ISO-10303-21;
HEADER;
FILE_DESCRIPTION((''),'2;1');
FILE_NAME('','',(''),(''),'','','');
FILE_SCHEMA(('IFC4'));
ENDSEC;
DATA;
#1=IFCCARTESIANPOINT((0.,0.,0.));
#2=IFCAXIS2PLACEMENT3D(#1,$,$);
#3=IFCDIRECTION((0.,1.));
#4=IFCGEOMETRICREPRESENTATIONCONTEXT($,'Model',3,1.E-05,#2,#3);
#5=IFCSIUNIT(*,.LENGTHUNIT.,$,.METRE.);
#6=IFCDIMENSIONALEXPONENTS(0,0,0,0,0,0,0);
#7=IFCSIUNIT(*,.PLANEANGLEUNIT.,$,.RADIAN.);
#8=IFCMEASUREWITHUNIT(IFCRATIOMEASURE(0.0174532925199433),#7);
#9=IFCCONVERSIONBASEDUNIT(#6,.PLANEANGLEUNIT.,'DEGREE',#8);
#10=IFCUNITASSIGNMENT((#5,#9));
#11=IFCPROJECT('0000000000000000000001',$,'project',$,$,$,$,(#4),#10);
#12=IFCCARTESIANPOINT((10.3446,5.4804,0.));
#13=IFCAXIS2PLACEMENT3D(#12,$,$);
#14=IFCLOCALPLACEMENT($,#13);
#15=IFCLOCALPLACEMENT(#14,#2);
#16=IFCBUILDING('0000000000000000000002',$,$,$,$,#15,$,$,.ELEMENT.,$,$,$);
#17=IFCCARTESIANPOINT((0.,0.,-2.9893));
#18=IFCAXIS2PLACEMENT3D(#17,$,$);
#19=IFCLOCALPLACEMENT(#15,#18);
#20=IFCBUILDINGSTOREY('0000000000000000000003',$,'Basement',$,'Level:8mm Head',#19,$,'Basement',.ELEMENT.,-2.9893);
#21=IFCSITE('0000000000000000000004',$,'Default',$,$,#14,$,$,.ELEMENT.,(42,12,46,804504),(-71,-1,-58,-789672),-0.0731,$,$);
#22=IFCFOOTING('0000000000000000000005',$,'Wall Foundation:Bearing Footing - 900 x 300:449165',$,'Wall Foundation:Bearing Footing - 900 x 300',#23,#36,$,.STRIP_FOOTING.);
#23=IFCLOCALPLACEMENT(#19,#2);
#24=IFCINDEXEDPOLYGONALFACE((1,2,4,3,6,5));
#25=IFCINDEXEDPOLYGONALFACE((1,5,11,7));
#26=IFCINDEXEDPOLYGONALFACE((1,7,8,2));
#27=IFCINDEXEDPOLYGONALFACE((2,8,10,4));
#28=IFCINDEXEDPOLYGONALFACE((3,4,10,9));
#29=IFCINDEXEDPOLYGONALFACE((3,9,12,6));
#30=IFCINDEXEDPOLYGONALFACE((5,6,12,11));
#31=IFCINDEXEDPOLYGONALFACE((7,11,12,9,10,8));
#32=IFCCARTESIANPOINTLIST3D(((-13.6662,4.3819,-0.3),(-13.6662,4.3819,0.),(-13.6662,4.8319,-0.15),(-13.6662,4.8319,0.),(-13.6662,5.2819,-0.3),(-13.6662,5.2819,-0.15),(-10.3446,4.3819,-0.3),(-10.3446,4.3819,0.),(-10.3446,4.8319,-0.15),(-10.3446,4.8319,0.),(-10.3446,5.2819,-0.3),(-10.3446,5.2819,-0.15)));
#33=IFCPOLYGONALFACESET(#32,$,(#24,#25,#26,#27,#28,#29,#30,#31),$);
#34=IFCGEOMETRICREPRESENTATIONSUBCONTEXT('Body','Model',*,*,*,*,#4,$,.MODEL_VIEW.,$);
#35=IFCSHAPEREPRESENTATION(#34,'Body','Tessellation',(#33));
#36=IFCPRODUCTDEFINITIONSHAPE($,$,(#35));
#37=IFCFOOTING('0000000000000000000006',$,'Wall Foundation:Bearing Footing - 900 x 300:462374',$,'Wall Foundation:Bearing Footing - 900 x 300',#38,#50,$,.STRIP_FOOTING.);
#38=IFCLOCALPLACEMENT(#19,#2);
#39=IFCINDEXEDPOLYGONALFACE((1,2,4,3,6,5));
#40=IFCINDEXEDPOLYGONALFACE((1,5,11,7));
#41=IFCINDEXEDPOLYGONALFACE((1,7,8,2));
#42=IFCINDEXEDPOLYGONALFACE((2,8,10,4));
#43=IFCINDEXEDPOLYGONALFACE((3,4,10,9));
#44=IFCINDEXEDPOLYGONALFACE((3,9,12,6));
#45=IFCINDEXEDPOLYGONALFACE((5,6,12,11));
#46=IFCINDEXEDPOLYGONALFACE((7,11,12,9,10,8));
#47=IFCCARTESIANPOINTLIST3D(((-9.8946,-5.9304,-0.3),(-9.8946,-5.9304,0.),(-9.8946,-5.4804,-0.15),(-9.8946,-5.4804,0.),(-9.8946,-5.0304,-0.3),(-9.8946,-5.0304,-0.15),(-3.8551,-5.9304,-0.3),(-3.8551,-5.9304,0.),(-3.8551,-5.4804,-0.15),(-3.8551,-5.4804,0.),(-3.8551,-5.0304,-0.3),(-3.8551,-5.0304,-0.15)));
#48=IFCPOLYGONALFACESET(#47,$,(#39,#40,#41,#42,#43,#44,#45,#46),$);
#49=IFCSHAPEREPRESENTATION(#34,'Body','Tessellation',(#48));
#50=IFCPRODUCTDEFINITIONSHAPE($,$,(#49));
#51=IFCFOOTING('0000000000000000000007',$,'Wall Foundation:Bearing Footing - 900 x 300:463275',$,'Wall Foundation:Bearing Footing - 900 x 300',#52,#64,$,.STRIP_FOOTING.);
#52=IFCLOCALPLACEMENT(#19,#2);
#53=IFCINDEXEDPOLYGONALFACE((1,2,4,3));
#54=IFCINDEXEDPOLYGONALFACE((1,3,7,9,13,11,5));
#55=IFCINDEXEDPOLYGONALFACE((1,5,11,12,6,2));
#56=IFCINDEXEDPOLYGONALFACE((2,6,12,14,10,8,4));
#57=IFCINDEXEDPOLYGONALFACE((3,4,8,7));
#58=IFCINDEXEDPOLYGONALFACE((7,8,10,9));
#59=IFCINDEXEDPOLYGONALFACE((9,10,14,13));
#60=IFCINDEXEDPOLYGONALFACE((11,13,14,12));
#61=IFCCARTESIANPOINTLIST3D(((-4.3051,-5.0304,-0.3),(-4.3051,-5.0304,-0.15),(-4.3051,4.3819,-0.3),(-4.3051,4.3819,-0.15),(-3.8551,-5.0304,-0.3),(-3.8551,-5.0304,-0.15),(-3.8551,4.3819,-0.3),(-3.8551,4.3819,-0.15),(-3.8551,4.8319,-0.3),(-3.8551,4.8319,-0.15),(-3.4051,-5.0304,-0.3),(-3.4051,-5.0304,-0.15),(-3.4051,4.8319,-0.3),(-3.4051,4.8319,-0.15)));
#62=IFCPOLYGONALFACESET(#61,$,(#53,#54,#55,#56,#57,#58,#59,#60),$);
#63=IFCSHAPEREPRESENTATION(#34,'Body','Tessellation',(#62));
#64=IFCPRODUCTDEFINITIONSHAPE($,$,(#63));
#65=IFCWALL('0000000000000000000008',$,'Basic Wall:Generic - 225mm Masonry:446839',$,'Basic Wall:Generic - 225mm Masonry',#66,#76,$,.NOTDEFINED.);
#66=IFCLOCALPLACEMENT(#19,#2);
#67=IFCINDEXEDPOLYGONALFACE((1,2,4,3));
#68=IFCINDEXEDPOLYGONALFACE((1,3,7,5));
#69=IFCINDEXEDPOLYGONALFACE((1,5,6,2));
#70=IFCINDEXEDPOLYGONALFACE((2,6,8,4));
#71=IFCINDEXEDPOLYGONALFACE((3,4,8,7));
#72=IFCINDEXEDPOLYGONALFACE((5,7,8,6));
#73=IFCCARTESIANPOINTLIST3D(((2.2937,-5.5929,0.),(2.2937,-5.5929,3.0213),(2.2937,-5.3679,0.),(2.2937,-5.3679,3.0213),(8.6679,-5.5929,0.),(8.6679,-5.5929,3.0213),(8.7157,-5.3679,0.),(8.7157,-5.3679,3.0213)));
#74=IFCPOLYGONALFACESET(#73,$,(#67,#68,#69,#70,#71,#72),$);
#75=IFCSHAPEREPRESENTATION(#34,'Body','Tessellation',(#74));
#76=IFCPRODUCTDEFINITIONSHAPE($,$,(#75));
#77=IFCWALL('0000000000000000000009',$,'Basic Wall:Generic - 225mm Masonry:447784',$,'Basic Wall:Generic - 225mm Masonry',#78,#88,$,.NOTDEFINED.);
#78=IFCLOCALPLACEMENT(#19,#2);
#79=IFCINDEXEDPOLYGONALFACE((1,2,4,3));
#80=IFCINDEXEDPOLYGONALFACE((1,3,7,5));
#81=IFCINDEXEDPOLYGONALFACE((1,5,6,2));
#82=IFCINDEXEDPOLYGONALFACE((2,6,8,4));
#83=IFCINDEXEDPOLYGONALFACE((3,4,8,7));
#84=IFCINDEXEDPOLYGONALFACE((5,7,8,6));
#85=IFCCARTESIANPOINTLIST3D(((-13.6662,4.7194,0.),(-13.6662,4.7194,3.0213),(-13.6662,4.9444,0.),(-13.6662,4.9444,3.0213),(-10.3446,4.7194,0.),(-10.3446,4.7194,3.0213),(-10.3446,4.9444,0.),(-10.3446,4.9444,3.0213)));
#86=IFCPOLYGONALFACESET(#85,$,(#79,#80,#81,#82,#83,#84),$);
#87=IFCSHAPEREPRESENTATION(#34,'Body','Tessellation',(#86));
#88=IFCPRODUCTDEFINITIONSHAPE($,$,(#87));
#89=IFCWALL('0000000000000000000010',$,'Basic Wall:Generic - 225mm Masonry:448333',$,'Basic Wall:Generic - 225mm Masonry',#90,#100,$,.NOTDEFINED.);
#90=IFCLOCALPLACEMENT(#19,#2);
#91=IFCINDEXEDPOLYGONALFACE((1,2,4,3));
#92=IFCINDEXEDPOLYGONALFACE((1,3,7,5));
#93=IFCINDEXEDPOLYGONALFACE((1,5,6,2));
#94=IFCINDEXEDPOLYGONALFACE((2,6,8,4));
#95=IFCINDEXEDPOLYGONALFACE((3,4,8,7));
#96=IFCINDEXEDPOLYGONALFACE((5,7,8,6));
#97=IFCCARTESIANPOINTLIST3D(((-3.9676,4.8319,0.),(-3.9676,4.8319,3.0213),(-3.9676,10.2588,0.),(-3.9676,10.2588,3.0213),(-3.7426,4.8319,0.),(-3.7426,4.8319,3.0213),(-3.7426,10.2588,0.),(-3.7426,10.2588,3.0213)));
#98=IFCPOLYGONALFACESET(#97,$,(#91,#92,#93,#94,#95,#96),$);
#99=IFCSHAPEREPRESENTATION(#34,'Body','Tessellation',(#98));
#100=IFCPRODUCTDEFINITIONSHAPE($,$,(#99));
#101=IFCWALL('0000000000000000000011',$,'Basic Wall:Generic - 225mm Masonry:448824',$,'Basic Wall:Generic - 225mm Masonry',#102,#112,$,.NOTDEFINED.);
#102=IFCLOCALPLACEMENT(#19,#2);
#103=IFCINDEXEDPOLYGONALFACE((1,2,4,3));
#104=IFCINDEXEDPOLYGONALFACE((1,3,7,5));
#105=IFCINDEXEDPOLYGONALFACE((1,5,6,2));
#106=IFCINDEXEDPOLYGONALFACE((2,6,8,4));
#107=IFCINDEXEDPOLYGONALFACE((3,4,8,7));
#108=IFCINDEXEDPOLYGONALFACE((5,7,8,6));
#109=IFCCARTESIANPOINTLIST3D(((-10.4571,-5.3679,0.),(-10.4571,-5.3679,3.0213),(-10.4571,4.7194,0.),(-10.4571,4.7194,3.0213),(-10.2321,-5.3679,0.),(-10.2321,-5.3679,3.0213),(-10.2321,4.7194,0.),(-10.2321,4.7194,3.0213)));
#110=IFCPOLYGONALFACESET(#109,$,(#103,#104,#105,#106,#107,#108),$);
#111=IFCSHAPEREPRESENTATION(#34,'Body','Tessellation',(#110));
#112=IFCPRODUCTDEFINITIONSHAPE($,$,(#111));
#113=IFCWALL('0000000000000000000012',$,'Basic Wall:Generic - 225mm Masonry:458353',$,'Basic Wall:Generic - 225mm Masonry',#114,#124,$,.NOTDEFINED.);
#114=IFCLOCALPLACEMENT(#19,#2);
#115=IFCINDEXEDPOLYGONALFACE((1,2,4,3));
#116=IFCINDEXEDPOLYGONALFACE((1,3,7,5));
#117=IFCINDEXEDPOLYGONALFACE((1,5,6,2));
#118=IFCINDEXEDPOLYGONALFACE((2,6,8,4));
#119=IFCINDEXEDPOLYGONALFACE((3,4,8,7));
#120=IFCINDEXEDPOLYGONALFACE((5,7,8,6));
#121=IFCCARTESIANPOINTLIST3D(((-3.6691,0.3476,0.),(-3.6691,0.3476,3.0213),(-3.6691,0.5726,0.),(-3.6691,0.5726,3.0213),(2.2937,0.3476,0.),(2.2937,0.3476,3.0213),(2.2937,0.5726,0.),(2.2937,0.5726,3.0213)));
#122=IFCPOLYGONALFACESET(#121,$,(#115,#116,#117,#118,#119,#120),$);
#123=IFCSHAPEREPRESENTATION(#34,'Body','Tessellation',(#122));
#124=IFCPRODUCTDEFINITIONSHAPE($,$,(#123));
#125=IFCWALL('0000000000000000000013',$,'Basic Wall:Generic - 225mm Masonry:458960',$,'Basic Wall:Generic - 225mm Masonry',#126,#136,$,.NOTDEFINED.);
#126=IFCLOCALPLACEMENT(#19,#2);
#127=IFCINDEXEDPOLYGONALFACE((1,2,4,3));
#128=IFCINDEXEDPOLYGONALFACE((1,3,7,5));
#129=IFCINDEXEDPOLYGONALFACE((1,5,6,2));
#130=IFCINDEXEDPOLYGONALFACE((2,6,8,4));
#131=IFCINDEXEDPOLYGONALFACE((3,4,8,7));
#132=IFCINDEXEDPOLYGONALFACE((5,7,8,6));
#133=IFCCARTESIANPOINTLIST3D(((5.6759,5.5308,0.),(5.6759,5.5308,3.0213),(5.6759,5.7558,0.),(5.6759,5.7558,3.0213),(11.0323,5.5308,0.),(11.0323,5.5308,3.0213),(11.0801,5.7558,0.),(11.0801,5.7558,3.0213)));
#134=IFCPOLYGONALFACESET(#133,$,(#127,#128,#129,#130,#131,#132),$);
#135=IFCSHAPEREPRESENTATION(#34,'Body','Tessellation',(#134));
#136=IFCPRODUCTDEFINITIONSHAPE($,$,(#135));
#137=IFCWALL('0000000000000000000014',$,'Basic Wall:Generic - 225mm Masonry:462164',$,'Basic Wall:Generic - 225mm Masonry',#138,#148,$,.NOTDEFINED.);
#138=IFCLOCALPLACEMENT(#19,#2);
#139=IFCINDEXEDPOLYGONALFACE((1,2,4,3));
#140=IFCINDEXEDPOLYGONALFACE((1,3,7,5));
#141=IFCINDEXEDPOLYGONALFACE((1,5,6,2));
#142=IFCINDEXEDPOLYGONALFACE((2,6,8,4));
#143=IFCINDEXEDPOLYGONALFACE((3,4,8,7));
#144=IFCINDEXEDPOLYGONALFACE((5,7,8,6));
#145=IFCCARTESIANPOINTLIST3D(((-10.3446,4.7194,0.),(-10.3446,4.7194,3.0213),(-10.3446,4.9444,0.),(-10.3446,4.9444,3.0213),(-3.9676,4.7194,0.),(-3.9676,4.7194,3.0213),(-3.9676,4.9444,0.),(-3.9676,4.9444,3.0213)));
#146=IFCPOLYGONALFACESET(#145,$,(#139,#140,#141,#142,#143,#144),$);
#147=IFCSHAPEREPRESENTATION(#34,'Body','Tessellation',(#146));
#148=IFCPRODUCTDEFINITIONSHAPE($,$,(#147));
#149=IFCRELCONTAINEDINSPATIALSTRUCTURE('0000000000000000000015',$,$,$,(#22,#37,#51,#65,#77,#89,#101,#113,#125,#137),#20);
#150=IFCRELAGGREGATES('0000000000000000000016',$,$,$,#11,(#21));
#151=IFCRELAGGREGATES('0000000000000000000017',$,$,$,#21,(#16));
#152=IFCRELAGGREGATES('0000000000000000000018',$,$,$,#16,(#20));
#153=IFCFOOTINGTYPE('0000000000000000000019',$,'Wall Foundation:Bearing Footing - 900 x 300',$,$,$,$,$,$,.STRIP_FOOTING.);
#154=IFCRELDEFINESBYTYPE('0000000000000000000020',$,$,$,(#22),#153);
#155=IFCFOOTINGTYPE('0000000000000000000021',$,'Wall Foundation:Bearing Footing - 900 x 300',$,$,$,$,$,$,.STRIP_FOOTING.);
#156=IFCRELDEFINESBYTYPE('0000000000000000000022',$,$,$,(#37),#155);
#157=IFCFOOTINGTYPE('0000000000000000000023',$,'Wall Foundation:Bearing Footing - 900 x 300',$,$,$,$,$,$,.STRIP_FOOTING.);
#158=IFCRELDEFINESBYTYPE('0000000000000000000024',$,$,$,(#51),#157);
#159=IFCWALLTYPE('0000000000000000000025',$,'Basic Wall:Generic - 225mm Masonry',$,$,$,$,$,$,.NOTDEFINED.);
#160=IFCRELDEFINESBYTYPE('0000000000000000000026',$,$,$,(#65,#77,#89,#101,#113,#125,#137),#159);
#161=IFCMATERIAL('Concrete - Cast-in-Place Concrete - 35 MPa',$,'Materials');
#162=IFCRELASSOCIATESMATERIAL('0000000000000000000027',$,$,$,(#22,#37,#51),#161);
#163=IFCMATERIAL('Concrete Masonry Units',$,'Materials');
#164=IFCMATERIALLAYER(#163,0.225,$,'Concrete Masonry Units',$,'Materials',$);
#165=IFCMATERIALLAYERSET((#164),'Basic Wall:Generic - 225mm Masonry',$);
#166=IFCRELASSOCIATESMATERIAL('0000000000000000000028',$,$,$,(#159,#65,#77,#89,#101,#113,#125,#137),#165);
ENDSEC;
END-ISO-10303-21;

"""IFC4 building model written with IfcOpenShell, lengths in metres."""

from ifc_helpers import new_model, entity, si_unit, converted_unit, direction, frame, frame_2d, origin, place, context, subcontext, project, spatial, polyline, rectangle, outline, extrude, clip, bounded_halfspace, material, layer, layer_set, layer_usage, type_object, element, save


model = new_model("IFC4")

# Units and contexts
model_context = context("Model", 3, precision=1e-05, world=origin(), true_north=direction((0.0, 1.0)))
body_context = subcontext(model_context, "Body", "Model", "MODEL_VIEW")
ifc_project = project(units=[si_unit("LENGTHUNIT", "METRE"), converted_unit("PLANEANGLEUNIT", "DEGREE", entity("IfcRatioMeasure", 0.0174532925199433), si_unit("PLANEANGLEUNIT", "RADIAN"), dimensions=[0, 0, 0, 0, 0, 0, 0])], contexts=[model_context])

# Site, building, storey
site_placement = place(None, frame((10.3446, 5.4804, 0.0)))
site = spatial("IfcSite", under=ifc_project, at=site_placement, Name="Default", CompositionType="ELEMENT", RefLatitude=(42, 12, 46, 804504), RefLongitude=(-71, -1, -58, -789672), RefElevation=-0.0731)
building_placement = place(site_placement, origin())
building = spatial("IfcBuilding", under=site, at=building_placement, CompositionType="ELEMENT")
storey_placement = place(building_placement, frame((0.0, 0.0, -2.9893)))
storey = spatial("IfcBuildingStorey", under=building, at=storey_placement, Name="Basement", ObjectType="Level:8mm Head", LongName="Basement", CompositionType="ELEMENT", Elevation=-2.9893)

# Footings
ifc_material_1 = material(Name="Concrete - Cast-in-Place Concrete - 35 MPa", Category="Materials")
footing_type_1 = type_object("IfcFootingType", Name="Wall Foundation:Bearing Footing - 900 x 300", PredefinedType="STRIP_FOOTING")
footing_1_placement = place(storey_placement, frame((-13.6662, 4.3819, -0.3)))
element("IfcFooting", 1, at=footing_1_placement, inside=storey, type_object=footing_type_1, material=ifc_material_1, Name="Wall Foundation:Bearing Footing - 900 x 300:449165", ObjectType="Wall Foundation:Bearing Footing - 900 x 300", PredefinedType="STRIP_FOOTING", context=body_context, shape_type="SweptSolid", body=[
    extrude(outline(polyline([(-0.15, -0.45), (0.0, -0.45), (0.0, 0.0), (0.15, 0.0), (0.15, 0.45), (-0.15, 0.45), (-0.15, -0.45)])), frame((0.0, 0.45, 0.15), z_axis=(1.0, 0.0, 0.0), x_axis=(0.0, 0.0, 1.0)), (0.0, 0.0, 1.0), 3.3216),
])
footing_type_2 = type_object("IfcFootingType", Name="Wall Foundation:Bearing Footing - 900 x 300", PredefinedType="STRIP_FOOTING")
footing_2_placement = place(storey_placement, frame((-9.8946, -5.9304, -0.3)))
element("IfcFooting", 2, at=footing_2_placement, inside=storey, type_object=footing_type_2, material=ifc_material_1, Name="Wall Foundation:Bearing Footing - 900 x 300:462374", ObjectType="Wall Foundation:Bearing Footing - 900 x 300", PredefinedType="STRIP_FOOTING", context=body_context, shape_type="SweptSolid", body=[
    extrude(outline(polyline([(-0.45, -0.15), (0.45, -0.15), (0.45, 0.0), (0.0, 0.0), (0.0, 0.15), (-0.45, 0.15), (-0.45, -0.15)])), frame((0.0, 0.45, 0.15), z_axis=(1.0, 0.0, 0.0), x_axis=(0.0, 1.0, 0.0)), (0.0, 0.0, 1.0), 6.0395),
])
footing_type_3 = type_object("IfcFootingType", Name="Wall Foundation:Bearing Footing - 900 x 300", PredefinedType="STRIP_FOOTING")
footing_3_placement = place(storey_placement, frame((-4.3051, -5.0304, -0.3)))
element("IfcFooting", 3, at=footing_3_placement, inside=storey, type_object=footing_type_3, material=ifc_material_1, Name="Wall Foundation:Bearing Footing - 900 x 300:463275", ObjectType="Wall Foundation:Bearing Footing - 900 x 300", PredefinedType="STRIP_FOOTING", context=body_context, shape_type="SweptSolid", body=[
    extrude(outline(polyline([(-4.3553, 0.0), (-4.3553, -0.45), (5.507, -0.45), (5.507, 0.0), (5.507, 0.45), (-3.9053, 0.45), (-3.9053, 0.0), (-4.3553, 0.0)])), frame((0.45, 5.507, 0.0), z_axis=(0.0, 0.0, -1.0), x_axis=(0.0, -1.0, 0.0)), (0.0, 0.0, -1.0), 0.15),
])

# Walls
ifc_material_2 = material(Name="Concrete Masonry Units", Category="Materials")
ifc_layer_1 = layer(ifc_material_2, 0.225, Name="Concrete Masonry Units", Category="Materials")
ifc_layer_set_1 = layer_set([ifc_layer_1], Name="Basic Wall:Generic - 225mm Masonry")
wall_type = type_object("IfcWallType", Name="Basic Wall:Generic - 225mm Masonry", PredefinedType="NOTDEFINED", material=ifc_layer_set_1)
ifc_layer_usage_1 = layer_usage(ifc_layer_set_1, "AXIS2", "NEGATIVE", 0.1125)
wall_1_placement = place(storey_placement, frame((8.7157, -5.4804, 0.0), z_axis=(0.0, 0.0, 1.0), x_axis=(-1.0, 0.0, 0.0)))
element("IfcWall", 4, at=wall_1_placement, inside=storey, type_object=wall_type, material=ifc_layer_usage_1, Name="Basic Wall:Generic - 225mm Masonry:446839", ObjectType="Basic Wall:Generic - 225mm Masonry", PredefinedType="NOTDEFINED", context=body_context, shape_type="Clipping", body=[
    clip(extrude(outline(polyline([(6.4221, -0.1125), (6.4221, 0.1125), (0.0478, 0.1125), (0.0, -0.1125), (6.3096, -0.1125), (6.4221, -0.1125)])), origin(), (0.0, 0.0, 1.0), 3.0213), bounded_halfspace(frame((0.0, -0.1125, 3.0213), z_axis=(0.0, 0.0, -1.0), x_axis=(1.0, 0.0, 0.0)), True, frame((0.0, -0.1125, 3.0213)), polyline([(0.0, 0.0), (6.3096, 0.0), (6.4139, 0.0), (6.4139, 0.1125), (0.0239, 0.1125), (0.0, 0.0)]))),
])
ifc_layer_usage_2 = layer_usage(ifc_layer_set_1, "AXIS2", "NEGATIVE", 0.1125)
wall_2_placement = place(storey_placement, frame((-13.6662, 4.8319, 0.0)))
element("IfcWall", 5, at=wall_2_placement, inside=storey, type_object=wall_type, material=ifc_layer_usage_2, Name="Basic Wall:Generic - 225mm Masonry:447784", ObjectType="Basic Wall:Generic - 225mm Masonry", PredefinedType="NOTDEFINED", context=body_context, shape_type="Clipping", body=[
    clip(extrude(rectangle(XDim=3.3216, YDim=0.225, at=frame_2d((1.6608, 0.0), x_axis=(-1.0, 0.0))), origin(), (0.0, 0.0, 1.0), 3.0213), bounded_halfspace(frame((3.3216, 0.0, 3.0213), z_axis=(0.0, 0.0, -1.0), x_axis=(1.0, 0.0, 0.0)), True, frame((3.3216, 0.0, 3.0213)), polyline([(0.0, 0.0), (0.0, 0.1125), (-3.3216, 0.1125), (-3.3216, 0.0), (0.0, 0.0)]))),
])
ifc_layer_usage_3 = layer_usage(ifc_layer_set_1, "AXIS2", "NEGATIVE", 0.1125)
wall_3_placement = place(storey_placement, frame((-3.8551, 10.2588, 0.0), z_axis=(0.0, 0.0, 1.0), x_axis=(0.0, -1.0, 0.0)))
element("IfcWall", 6, at=wall_3_placement, inside=storey, type_object=wall_type, material=ifc_layer_usage_3, Name="Basic Wall:Generic - 225mm Masonry:448333", ObjectType="Basic Wall:Generic - 225mm Masonry", PredefinedType="NOTDEFINED", context=body_context, shape_type="Clipping", body=[
    clip(clip(extrude(rectangle(XDim=5.4269, YDim=0.225, at=frame_2d((2.7135, 0.0), x_axis=(-1.0, 0.0))), origin(), (0.0, 0.0, 1.0), 3.0213), bounded_halfspace(frame((0.0, -0.1125, 3.0213), z_axis=(0.0, 0.0, -1.0), x_axis=(0.0, 1.0, 0.0)), True, frame((0.0, -0.1125, 3.0213)), polyline([(0.0, 0.0), (5.3144, 0.0), (5.4269, 0.0), (5.4269, 0.1125), (0.0, 0.1125), (0.0, 0.0)]))), bounded_halfspace(frame((5.4269, 0.0, 3.0213), z_axis=(0.0, 0.0, -1.0), x_axis=(-1.0, 0.0, 0.0)), True, frame((5.4269, 0.0, 3.0213)), polyline([(0.0, 0.0), (0.0, 0.1125), (-5.4269, 0.1125), (-5.4269, 0.0), (0.0, 0.0)]))),
])
ifc_layer_usage_4 = layer_usage(ifc_layer_set_1, "AXIS2", "NEGATIVE", 0.1125)
wall_4_placement = place(storey_placement, frame((-10.3446, -5.3679, 0.0), z_axis=(0.0, 0.0, 1.0), x_axis=(0.0, 1.0, 0.0)))
element("IfcWall", 7, at=wall_4_placement, inside=storey, type_object=wall_type, material=ifc_layer_usage_4, Name="Basic Wall:Generic - 225mm Masonry:448824", ObjectType="Basic Wall:Generic - 225mm Masonry", PredefinedType="NOTDEFINED", context=body_context, shape_type="Clipping", body=[
    clip(extrude(rectangle(XDim=10.0873, YDim=0.225, at=frame_2d((5.0437, 0.0), x_axis=(-1.0, 0.0))), origin(), (0.0, 0.0, 1.0), 3.0213), bounded_halfspace(frame((0.0, -0.1125, 3.0213), z_axis=(0.0, 0.0, -1.0), x_axis=(-1.0, 0.0, 0.0)), True, frame((0.0, -0.1125, 3.0213)), polyline([(0.0, 0.0), (10.0873, 0.0), (10.0873, 0.1125), (0.0, 0.1125), (0.0, 0.0)]))),
])
ifc_layer_usage_5 = layer_usage(ifc_layer_set_1, "AXIS2", "NEGATIVE", 0.1125)
wall_5_placement = place(storey_placement, frame((-3.6691, 0.4601, 0.0)))
element("IfcWall", 8, at=wall_5_placement, inside=storey, type_object=wall_type, material=ifc_layer_usage_5, Name="Basic Wall:Generic - 225mm Masonry:458353", ObjectType="Basic Wall:Generic - 225mm Masonry", PredefinedType="NOTDEFINED", context=body_context, shape_type="Clipping", body=[
    clip(clip(extrude(rectangle(XDim=5.9627, YDim=0.225, at=frame_2d((2.9814, 0.0), x_axis=(-1.0, 0.0))), origin(), (0.0, 0.0, 1.0), 3.0213), bounded_halfspace(frame((0.0, -0.1125, 3.0213), z_axis=(0.0, 0.0, -1.0), x_axis=(0.0, 1.0, 0.0)), True, frame((0.0, -0.1125, 3.0213)), polyline([(0.0, 0.0), (5.9627, 0.0), (5.9627, 0.1125), (0.0, 0.1125), (0.0, 0.0)]))), bounded_halfspace(frame((5.9627, 0.0, 3.0213), z_axis=(0.0, 0.0, -1.0), x_axis=(0.0, 1.0, 0.0)), True, frame((5.9627, 0.0, 3.0213)), polyline([(0.0, 0.0), (0.0, 0.1125), (-0.1125, 0.1125), (-5.9627, 0.1125), (-5.9627, 0.0065), (-5.9627, 0.0), (0.0, 0.0)]))),
])
ifc_layer_usage_6 = layer_usage(ifc_layer_set_1, "AXIS2", "NEGATIVE", 0.1125)
wall_6_placement = place(storey_placement, frame((5.6759, 5.6433, 0.0)))
element("IfcWall", 9, at=wall_6_placement, inside=storey, type_object=wall_type, material=ifc_layer_usage_6, Name="Basic Wall:Generic - 225mm Masonry:458960", ObjectType="Basic Wall:Generic - 225mm Masonry", PredefinedType="NOTDEFINED", context=body_context, shape_type="Clipping", body=[
    clip(extrude(outline(polyline([(5.3564, -0.1125), (5.4043, 0.1125), (0.0, 0.1125), (0.0, -0.1125), (5.3564, -0.1125)])), origin(), (0.0, 0.0, 1.0), 3.0213), bounded_halfspace(frame((0.0, -0.1125, 3.0213), z_axis=(0.0, 0.0, -1.0), x_axis=(0.0, 1.0, 0.0)), True, frame((0.0, -0.1125, 3.0213)), polyline([(0.0, 0.0), (5.3564, 0.0), (5.4043, 0.225), (0.0, 0.225), (0.0, 0.0)]))),
])
ifc_layer_usage_7 = layer_usage(ifc_layer_set_1, "AXIS2", "NEGATIVE", 0.1125)
wall_7_placement = place(storey_placement, frame((-10.3446, 4.8319, 0.0)))
element("IfcWall", 10, at=wall_7_placement, inside=storey, type_object=wall_type, material=ifc_layer_usage_7, Name="Basic Wall:Generic - 225mm Masonry:462164", ObjectType="Basic Wall:Generic - 225mm Masonry", PredefinedType="NOTDEFINED", context=body_context, shape_type="Clipping", body=[
    clip(clip(extrude(rectangle(XDim=6.377, YDim=0.225, at=frame_2d((3.1885, 0.0), x_axis=(-1.0, 0.0))), origin(), (0.0, 0.0, 1.0), 3.0213), bounded_halfspace(frame((0.0, -0.1125, 3.0213), z_axis=(0.0, 0.0, -1.0), x_axis=(0.0, -1.0, 0.0)), True, frame((0.0, -0.1125, 3.0213)), polyline([(0.0, 0.0), (0.1125, 0.0), (6.377, 0.0), (6.377, 0.1125), (0.0, 0.1125), (0.0, 0.0)]))), bounded_halfspace(frame((6.377, 0.0, 3.0213), z_axis=(0.0, 0.0, -1.0), x_axis=(1.0, 0.0, 0.0)), True, frame((6.377, 0.0, 3.0213)), polyline([(0.0, 0.0), (0.0, 0.1125), (-6.377, 0.1125), (-6.377, 0.0), (0.0, 0.0)]))),
])

save(model, "model.ifc")
